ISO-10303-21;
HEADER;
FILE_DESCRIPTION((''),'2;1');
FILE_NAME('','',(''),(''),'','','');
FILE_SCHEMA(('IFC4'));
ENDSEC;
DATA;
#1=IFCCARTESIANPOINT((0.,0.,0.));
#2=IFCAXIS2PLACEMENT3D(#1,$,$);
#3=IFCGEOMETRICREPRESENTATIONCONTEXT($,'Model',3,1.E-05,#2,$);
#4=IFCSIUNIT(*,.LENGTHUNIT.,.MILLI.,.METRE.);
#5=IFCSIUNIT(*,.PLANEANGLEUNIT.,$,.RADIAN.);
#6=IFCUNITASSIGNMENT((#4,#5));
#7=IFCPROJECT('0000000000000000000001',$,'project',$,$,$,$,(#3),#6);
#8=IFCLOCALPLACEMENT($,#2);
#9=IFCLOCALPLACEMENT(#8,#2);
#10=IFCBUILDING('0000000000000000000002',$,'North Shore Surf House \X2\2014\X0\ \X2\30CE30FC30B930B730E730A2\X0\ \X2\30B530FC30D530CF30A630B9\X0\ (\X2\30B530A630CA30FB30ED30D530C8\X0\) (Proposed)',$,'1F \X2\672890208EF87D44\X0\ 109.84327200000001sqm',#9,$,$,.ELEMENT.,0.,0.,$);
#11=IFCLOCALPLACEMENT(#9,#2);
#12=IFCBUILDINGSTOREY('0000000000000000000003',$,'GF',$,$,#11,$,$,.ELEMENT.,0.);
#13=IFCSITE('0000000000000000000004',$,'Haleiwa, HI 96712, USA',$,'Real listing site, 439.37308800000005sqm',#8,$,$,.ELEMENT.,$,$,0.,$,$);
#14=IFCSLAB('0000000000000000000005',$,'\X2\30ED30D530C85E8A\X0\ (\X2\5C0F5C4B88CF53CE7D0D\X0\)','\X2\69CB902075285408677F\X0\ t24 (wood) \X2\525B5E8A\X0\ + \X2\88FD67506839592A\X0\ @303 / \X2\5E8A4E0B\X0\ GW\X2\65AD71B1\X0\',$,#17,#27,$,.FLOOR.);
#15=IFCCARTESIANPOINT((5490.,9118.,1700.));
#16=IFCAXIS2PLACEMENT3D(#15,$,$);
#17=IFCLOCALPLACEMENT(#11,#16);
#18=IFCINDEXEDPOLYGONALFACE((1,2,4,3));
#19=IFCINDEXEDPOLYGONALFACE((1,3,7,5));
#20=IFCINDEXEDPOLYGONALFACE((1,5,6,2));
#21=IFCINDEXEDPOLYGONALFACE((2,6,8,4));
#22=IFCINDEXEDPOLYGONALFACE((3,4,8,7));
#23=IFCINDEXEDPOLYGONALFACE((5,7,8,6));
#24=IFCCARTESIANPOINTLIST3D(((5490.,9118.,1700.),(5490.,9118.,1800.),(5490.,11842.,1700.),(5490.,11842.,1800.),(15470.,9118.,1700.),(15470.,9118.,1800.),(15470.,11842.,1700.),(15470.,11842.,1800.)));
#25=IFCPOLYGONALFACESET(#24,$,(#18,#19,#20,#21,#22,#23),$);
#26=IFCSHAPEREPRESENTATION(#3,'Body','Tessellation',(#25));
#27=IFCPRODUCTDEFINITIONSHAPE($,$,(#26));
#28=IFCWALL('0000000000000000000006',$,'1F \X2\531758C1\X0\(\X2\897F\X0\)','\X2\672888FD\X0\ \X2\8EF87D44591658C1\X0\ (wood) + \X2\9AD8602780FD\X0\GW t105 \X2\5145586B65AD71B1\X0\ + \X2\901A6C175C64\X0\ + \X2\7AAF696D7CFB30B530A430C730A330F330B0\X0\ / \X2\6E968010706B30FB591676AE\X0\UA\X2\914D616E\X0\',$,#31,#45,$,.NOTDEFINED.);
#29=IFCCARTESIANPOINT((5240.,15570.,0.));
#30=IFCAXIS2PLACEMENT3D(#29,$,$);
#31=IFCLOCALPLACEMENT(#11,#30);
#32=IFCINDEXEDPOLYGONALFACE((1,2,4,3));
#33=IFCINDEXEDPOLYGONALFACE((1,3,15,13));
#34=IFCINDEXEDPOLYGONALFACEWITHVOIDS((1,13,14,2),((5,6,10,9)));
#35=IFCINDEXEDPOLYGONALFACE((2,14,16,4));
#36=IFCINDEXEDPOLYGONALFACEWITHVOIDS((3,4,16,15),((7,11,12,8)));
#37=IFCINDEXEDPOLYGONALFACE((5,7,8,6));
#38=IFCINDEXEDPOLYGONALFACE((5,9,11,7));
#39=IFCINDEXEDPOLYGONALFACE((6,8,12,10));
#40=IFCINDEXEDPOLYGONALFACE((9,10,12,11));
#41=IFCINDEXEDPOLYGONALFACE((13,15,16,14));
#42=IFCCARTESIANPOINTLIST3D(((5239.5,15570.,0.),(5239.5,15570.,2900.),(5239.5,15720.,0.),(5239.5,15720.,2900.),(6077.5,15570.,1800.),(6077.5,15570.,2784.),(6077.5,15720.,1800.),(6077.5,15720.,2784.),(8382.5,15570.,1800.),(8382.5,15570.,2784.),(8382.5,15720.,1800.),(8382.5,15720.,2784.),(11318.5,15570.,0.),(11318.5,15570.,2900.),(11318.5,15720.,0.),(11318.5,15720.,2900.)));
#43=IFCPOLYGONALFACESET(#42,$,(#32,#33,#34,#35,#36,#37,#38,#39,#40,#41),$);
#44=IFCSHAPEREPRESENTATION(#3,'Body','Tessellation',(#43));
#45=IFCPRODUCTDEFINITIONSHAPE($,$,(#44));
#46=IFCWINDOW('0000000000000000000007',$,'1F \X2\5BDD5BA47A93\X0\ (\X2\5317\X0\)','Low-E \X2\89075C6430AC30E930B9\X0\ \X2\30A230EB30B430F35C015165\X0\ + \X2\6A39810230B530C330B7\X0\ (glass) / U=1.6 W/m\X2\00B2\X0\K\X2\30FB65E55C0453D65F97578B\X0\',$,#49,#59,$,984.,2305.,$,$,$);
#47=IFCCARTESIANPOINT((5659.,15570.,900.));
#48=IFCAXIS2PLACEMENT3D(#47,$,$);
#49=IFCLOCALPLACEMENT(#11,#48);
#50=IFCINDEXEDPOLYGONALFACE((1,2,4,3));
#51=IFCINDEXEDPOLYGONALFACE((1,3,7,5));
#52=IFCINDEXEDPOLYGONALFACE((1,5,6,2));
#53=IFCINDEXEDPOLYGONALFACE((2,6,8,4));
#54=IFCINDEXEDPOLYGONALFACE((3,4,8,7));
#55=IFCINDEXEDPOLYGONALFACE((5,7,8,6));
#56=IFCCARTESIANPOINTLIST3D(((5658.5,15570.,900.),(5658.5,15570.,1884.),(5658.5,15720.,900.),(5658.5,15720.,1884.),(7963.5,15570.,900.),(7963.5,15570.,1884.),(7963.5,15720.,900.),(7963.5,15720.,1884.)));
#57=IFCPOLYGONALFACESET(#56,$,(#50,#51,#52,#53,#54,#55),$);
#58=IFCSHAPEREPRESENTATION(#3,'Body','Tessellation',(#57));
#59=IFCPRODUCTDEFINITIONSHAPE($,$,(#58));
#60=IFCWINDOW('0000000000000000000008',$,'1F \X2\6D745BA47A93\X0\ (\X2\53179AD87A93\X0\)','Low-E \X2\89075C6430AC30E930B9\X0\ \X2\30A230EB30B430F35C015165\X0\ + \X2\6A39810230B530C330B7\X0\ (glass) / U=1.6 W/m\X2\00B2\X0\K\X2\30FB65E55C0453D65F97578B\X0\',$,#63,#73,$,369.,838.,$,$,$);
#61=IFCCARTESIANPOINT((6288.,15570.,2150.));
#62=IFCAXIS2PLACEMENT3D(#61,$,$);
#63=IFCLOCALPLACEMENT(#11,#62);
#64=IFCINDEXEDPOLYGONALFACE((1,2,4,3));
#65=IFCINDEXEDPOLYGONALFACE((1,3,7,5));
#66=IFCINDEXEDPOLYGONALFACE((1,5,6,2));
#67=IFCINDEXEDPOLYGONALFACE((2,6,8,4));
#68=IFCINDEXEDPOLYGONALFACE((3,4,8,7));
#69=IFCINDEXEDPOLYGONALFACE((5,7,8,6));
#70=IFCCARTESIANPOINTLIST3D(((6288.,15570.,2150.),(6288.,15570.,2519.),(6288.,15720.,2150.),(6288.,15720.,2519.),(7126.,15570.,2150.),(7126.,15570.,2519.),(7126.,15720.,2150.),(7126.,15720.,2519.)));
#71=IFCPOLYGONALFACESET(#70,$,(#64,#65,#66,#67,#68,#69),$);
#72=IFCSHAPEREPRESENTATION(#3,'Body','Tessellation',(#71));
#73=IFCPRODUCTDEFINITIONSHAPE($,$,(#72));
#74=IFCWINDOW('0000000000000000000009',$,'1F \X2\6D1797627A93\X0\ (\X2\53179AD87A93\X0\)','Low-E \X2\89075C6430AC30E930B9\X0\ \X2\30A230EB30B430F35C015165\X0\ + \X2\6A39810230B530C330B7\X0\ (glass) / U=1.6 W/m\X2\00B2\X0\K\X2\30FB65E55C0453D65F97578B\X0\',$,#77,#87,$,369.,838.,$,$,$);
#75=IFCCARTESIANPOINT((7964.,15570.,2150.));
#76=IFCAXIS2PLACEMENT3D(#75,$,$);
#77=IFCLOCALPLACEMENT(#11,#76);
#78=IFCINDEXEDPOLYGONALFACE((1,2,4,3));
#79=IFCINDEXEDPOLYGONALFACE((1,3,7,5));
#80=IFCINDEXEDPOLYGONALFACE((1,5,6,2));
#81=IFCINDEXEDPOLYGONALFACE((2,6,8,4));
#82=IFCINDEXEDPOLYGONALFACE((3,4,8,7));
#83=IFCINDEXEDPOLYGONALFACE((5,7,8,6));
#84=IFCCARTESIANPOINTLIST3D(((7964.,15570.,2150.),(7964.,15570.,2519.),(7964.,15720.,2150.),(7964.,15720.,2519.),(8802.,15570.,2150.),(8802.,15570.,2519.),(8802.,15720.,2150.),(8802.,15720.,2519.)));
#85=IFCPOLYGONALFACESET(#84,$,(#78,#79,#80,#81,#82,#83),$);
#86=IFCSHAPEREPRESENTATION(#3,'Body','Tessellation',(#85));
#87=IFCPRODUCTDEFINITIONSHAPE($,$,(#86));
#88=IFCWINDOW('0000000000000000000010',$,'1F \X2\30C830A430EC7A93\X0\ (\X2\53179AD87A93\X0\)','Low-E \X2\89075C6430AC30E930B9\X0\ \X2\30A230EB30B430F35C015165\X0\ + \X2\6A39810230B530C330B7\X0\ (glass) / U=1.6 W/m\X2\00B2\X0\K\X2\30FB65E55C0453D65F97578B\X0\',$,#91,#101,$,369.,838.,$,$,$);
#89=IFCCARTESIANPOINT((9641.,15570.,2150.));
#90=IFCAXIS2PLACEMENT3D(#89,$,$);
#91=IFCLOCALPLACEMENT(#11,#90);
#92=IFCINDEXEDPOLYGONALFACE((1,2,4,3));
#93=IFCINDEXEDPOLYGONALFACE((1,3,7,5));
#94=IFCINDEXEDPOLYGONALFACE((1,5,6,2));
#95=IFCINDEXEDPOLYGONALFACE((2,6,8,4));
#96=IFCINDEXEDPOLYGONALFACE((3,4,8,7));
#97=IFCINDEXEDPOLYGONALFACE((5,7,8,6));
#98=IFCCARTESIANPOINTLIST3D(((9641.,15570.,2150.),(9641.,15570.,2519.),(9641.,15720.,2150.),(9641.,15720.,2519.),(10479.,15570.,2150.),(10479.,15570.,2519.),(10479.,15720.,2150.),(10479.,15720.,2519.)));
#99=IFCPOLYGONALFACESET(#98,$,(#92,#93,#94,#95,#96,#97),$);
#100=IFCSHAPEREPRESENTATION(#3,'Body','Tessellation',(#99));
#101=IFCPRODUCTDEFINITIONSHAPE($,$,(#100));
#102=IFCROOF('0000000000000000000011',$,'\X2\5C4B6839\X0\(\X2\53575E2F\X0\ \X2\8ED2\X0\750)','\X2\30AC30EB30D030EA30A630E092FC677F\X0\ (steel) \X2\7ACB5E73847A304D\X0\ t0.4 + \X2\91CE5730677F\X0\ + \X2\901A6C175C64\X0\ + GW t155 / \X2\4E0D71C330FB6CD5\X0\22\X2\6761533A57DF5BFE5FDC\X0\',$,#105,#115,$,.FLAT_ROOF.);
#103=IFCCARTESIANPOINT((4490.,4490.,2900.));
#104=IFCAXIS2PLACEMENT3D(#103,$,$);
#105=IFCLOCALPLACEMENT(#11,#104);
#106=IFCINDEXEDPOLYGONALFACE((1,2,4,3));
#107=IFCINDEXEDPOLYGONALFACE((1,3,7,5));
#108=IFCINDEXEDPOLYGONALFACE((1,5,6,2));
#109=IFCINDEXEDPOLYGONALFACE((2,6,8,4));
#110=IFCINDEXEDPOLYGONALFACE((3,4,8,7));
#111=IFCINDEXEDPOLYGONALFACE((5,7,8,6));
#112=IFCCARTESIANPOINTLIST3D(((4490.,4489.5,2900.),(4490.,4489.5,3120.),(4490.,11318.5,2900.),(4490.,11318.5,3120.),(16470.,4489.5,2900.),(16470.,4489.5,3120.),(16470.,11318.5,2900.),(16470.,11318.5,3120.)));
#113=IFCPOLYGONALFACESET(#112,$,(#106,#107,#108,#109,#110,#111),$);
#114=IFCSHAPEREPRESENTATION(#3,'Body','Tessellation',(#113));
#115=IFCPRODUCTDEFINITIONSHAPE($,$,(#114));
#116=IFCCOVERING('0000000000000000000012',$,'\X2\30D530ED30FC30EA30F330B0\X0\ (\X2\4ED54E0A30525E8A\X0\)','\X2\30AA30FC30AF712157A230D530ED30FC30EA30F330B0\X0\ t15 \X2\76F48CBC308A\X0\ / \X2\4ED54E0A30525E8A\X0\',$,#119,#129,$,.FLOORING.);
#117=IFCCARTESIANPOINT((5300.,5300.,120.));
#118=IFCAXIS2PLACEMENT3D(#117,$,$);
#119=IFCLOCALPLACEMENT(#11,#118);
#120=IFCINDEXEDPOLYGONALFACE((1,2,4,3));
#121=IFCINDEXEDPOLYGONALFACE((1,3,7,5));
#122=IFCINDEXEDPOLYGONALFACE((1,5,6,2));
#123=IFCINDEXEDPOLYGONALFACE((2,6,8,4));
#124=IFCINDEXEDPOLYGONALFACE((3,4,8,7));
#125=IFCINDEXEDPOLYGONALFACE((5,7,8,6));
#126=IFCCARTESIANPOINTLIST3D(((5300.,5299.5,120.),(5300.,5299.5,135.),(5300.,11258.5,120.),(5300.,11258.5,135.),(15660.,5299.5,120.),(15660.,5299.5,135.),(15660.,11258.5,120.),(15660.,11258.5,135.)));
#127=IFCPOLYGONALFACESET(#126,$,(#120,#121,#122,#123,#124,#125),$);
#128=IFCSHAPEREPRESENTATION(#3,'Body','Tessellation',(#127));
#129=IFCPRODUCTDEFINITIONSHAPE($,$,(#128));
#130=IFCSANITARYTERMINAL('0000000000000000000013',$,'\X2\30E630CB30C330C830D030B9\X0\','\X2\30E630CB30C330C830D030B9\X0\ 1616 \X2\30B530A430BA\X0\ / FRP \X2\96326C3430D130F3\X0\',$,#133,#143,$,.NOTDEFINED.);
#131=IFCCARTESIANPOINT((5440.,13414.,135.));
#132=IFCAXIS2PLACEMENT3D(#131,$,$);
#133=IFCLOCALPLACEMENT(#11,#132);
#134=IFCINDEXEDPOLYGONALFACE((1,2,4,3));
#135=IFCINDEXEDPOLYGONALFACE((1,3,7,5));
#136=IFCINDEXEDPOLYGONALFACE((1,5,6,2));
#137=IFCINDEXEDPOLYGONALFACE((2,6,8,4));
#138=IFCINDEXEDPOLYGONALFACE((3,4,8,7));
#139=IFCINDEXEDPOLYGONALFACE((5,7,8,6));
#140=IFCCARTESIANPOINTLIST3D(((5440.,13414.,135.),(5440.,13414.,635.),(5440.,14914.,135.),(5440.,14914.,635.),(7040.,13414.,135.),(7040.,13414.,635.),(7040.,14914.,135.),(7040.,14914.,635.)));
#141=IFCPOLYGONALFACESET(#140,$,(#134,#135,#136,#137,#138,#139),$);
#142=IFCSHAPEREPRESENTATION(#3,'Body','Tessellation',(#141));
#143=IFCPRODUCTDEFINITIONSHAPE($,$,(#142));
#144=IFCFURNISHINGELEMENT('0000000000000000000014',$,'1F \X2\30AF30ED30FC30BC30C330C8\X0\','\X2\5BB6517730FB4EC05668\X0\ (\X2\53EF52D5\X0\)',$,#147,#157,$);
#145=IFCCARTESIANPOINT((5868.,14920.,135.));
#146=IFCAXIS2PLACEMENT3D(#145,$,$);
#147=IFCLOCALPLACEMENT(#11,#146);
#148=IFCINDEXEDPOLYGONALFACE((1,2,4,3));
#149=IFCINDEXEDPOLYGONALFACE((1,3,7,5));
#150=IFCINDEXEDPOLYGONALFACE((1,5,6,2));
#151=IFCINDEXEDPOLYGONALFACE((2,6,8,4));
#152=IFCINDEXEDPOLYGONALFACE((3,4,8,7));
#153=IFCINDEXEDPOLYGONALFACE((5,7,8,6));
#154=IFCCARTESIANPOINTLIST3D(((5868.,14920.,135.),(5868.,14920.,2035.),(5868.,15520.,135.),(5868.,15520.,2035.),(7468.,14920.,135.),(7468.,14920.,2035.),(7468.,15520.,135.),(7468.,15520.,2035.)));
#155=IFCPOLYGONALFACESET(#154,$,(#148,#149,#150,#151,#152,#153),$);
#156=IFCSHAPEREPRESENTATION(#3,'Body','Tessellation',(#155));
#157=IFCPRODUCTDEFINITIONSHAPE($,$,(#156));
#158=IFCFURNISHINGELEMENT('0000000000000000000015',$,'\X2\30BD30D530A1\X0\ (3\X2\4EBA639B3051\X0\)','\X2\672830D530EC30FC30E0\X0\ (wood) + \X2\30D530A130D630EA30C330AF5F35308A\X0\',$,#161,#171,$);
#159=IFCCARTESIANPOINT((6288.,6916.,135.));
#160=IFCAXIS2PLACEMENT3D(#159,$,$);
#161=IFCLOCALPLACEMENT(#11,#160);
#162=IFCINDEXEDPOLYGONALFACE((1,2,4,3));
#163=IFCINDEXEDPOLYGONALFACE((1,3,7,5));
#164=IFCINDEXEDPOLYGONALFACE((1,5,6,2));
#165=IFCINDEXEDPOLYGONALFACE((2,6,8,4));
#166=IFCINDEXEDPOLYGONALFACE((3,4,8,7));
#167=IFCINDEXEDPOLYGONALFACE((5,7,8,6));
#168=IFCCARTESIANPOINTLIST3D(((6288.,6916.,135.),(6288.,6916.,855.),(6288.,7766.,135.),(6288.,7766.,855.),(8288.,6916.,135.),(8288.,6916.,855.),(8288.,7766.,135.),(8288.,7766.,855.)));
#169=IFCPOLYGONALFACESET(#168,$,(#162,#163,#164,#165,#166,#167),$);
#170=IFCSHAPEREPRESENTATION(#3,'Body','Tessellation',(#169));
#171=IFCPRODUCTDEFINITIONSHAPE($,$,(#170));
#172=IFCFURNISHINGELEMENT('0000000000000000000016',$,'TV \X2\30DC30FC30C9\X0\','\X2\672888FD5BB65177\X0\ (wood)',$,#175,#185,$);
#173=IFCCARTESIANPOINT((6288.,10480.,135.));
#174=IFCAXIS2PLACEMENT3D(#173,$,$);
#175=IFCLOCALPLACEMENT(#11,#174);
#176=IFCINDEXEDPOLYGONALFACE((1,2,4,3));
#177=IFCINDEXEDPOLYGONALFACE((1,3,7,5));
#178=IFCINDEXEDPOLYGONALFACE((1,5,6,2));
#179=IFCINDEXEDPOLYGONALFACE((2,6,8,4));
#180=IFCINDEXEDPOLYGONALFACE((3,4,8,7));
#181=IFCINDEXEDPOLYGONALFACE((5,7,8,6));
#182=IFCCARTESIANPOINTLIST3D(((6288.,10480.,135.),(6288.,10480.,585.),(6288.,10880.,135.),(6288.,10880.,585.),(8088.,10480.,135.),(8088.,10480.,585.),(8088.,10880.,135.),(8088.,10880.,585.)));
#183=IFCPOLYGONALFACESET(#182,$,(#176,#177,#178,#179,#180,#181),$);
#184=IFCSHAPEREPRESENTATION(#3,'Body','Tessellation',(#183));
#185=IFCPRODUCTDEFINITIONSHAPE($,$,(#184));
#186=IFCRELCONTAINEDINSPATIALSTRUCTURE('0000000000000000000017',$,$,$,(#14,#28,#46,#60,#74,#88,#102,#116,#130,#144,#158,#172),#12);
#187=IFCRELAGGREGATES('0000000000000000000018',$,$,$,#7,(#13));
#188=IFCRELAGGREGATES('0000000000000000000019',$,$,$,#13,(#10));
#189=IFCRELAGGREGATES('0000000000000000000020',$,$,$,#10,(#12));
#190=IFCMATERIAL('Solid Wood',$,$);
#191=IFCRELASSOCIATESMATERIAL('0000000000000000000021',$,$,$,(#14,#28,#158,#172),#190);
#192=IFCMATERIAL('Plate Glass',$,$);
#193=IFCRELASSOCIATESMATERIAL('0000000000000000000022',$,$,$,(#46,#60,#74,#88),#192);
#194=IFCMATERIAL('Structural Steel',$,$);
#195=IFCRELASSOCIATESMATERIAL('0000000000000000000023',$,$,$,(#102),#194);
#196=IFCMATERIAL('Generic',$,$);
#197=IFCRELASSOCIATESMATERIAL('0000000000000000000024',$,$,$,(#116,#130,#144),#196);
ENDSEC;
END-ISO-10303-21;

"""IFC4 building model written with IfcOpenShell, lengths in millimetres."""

from ifc_helpers import new_model, si_unit, frame, frame_2d, origin, place, context, project, spatial, rectangle, extrude, material, element, fill, save


model = new_model("IFC4")

# Units and contexts
model_context = context("Model", 3, precision=1e-05, world=origin())
ifc_project = project(units=[si_unit("LENGTHUNIT", "METRE", prefix="MILLI"), si_unit("PLANEANGLEUNIT", "RADIAN")], contexts=[model_context])

# Site, building, storey
site_placement = place(None, origin())
site = spatial("IfcSite", under=ifc_project, at=site_placement, Name="Haleiwa, HI 96712, USA", ObjectType="Real listing site, 439.37308800000005sqm", CompositionType="ELEMENT", RefElevation=0.0)
building_placement = place(site_placement, origin())
building = spatial("IfcBuilding", under=site, at=building_placement, Name="North Shore Surf House — ノースショア サーフハウス (サウナ・ロフト) (Proposed)", ObjectType="1F 木造軸組 109.84327200000001sqm", CompositionType="ELEMENT", ElevationOfRefHeight=0.0, ElevationOfTerrain=0.0)
storey_placement = place(building_placement, origin())
storey = spatial("IfcBuildingStorey", under=building, at=storey_placement, Name="GF", CompositionType="ELEMENT", Elevation=0.0)

# Slab
ifc_material_1 = material(Name="Solid Wood")
slab_1_placement = place(storey_placement, frame((5490.0, 9118.0, 1700.0)))
element("IfcSlab", 1, at=slab_1_placement, inside=storey, material=ifc_material_1, Name="ロフト床 (小屋裏収納)", Description="構造用合板 t24 (wood) 剛床 + 製材根太 @303 / 床下 GW断熱", PredefinedType="FLOOR", context=model_context, shape_type="SweptSolid", body=[
    extrude(rectangle(XDim=9980.0, YDim=2724.0, at=frame_2d((4990.0, 1362.0))), frame((5490.0, 9118.0, 1700.0)), (0.0, 0.0, 1.0), 100.0),
])

# Shared definitions
ifc_material_2 = material(Name="Plate Glass")

# Wall, openings, windows
wall_1_placement = place(storey_placement, frame((5240.0, 15570.0, 0.0)))
wall_1 = element("IfcWall", 2, at=wall_1_placement, inside=storey, material=ifc_material_1, Name="1F 北壁(西)", Description="木製 軸組外壁 (wood) + 高性能GW t105 充填断熱 + 通気層 + 窯業系サイディング / 準耐火・外皮UA配慮", PredefinedType="NOTDEFINED", context=model_context, shape_type="SweptSolid", body=[
    extrude(rectangle(XDim=6079.0, YDim=150.0, at=frame_2d((3039.0, 75.0))), frame((5240.0, 15570.0, 0.0)), (0.0, 0.0, 1.0), 2900.0),
])
opening_1_placement = place(storey_placement, frame((5659.0, 15570.0, 900.0)))
opening_1 = element("IfcOpeningElement", 3, at=opening_1_placement, cuts=wall_1, PredefinedType="NOTDEFINED", context=model_context, shape_type="SweptSolid", body=[
    extrude(rectangle(XDim=2305.0, YDim=150.0, at=frame_2d((1152.0, 75.0))), frame((5659.0, 15570.0, 900.0)), (0.0, 0.0, 1.0), 984.0),
])
opening_2_placement = place(storey_placement, frame((6288.0, 15570.0, 2150.0)))
opening_2 = element("IfcOpeningElement", 4, at=opening_2_placement, cuts=wall_1, PredefinedType="NOTDEFINED", context=model_context, shape_type="SweptSolid", body=[
    extrude(rectangle(XDim=838.0, YDim=150.0, at=frame_2d((419.0, 75.0))), frame((6288.0, 15570.0, 2150.0)), (0.0, 0.0, 1.0), 369.0),
])
opening_3_placement = place(storey_placement, frame((7964.0, 15570.0, 2150.0)))
opening_3 = element("IfcOpeningElement", 5, at=opening_3_placement, cuts=wall_1, PredefinedType="NOTDEFINED", context=model_context, shape_type="SweptSolid", body=[
    extrude(rectangle(XDim=838.0, YDim=150.0, at=frame_2d((419.0, 75.0))), frame((7964.0, 15570.0, 2150.0)), (0.0, 0.0, 1.0), 369.0),
])
opening_4_placement = place(storey_placement, frame((9641.0, 15570.0, 2150.0)))
opening_4 = element("IfcOpeningElement", 6, at=opening_4_placement, cuts=wall_1, PredefinedType="NOTDEFINED", context=model_context, shape_type="SweptSolid", body=[
    extrude(rectangle(XDim=838.0, YDim=150.0, at=frame_2d((419.0, 75.0))), frame((9641.0, 15570.0, 2150.0)), (0.0, 0.0, 1.0), 369.0),
])
window_1_placement = place(storey_placement, frame((5659.0, 15570.0, 900.0)))
window_1 = element("IfcWindow", 7, at=window_1_placement, inside=storey, material=ifc_material_2, Name="1F 寝室窓 (北)", Description="Low-E 複層ガラス アルゴン封入 + 樹脂サッシ (glass) / U=1.6 W/m²K・日射取得型", OverallHeight=984.0, OverallWidth=2305.0, context=model_context, shape_type="SweptSolid", body=[
    extrude(rectangle(XDim=2305.0, YDim=150.0, at=frame_2d((1152.0, 75.0))), frame((5659.0, 15570.0, 900.0)), (0.0, 0.0, 1.0), 984.0),
])
fill(opening_1, window_1)
window_2_placement = place(storey_placement, frame((6288.0, 15570.0, 2150.0)))
window_2 = element("IfcWindow", 8, at=window_2_placement, inside=storey, material=ifc_material_2, Name="1F 浴室窓 (北高窓)", Description="Low-E 複層ガラス アルゴン封入 + 樹脂サッシ (glass) / U=1.6 W/m²K・日射取得型", OverallHeight=369.0, OverallWidth=838.0, context=model_context, shape_type="SweptSolid", body=[
    extrude(rectangle(XDim=838.0, YDim=150.0, at=frame_2d((419.0, 75.0))), frame((6288.0, 15570.0, 2150.0)), (0.0, 0.0, 1.0), 369.0),
])
fill(opening_2, window_2)
window_3_placement = place(storey_placement, frame((7964.0, 15570.0, 2150.0)))
window_3 = element("IfcWindow", 9, at=window_3_placement, inside=storey, material=ifc_material_2, Name="1F 洗面窓 (北高窓)", Description="Low-E 複層ガラス アルゴン封入 + 樹脂サッシ (glass) / U=1.6 W/m²K・日射取得型", OverallHeight=369.0, OverallWidth=838.0, context=model_context, shape_type="SweptSolid", body=[
    extrude(rectangle(XDim=838.0, YDim=150.0, at=frame_2d((419.0, 75.0))), frame((7964.0, 15570.0, 2150.0)), (0.0, 0.0, 1.0), 369.0),
])
fill(opening_3, window_3)
window_4_placement = place(storey_placement, frame((9641.0, 15570.0, 2150.0)))
window_4 = element("IfcWindow", 10, at=window_4_placement, inside=storey, material=ifc_material_2, Name="1F トイレ窓 (北高窓)", Description="Low-E 複層ガラス アルゴン封入 + 樹脂サッシ (glass) / U=1.6 W/m²K・日射取得型", OverallHeight=369.0, OverallWidth=838.0, context=model_context, shape_type="SweptSolid", body=[
    extrude(rectangle(XDim=838.0, YDim=150.0, at=frame_2d((419.0, 75.0))), frame((9641.0, 15570.0, 2150.0)), (0.0, 0.0, 1.0), 369.0),
])
fill(opening_4, window_4)

# Roof
ifc_material_3 = material(Name="Structural Steel")
roof_1_placement = place(storey_placement, frame((4490.0, 4490.0, 2900.0)))
element("IfcRoof", 11, at=roof_1_placement, inside=storey, material=ifc_material_3, Name="屋根(南帯 軒750)", Description="ガルバリウム鋼板 (steel) 立平葺き t0.4 + 野地板 + 通気層 + GW t155 / 不燃・法22条区域対応", PredefinedType="FLAT_ROOF", context=model_context, shape_type="SweptSolid", body=[
    extrude(rectangle(XDim=11980.0, YDim=6829.0, at=frame_2d((5990.0, 3414.0))), frame((4490.0, 4490.0, 2900.0)), (0.0, 0.0, 1.0), 220.0),
])

# Covering
ifc_material_4 = material(Name="Generic")
covering_1_placement = place(storey_placement, frame((5300.0, 5300.0, 120.0)))
element("IfcCovering", 12, at=covering_1_placement, inside=storey, material=ifc_material_4, Name="フローリング (仕上げ床)", Description="オーク無垢フローリング t15 直貼り / 仕上げ床", PredefinedType="FLOORING", context=model_context, shape_type="SweptSolid", body=[
    extrude(rectangle(XDim=10360.0, YDim=5959.0, at=frame_2d((5180.0, 2979.0))), frame((5300.0, 5300.0, 120.0)), (0.0, 0.0, 1.0), 15.0),
])

# Sanitary terminal
sanitary_terminal_placement = place(storey_placement, frame((5440.0, 13414.0, 135.0)))
element("IfcSanitaryTerminal", 13, at=sanitary_terminal_placement, inside=storey, material=ifc_material_4, Name="ユニットバス", Description="ユニットバス 1616 サイズ / FRP 防水パン", PredefinedType="NOTDEFINED", context=model_context, shape_type="SweptSolid", body=[
    extrude(rectangle(XDim=1600.0, YDim=1500.0, at=frame_2d((800.0, 750.0))), frame((5440.0, 13414.0, 135.0)), (0.0, 0.0, 1.0), 500.0),
])

# Furnishing elements
furnishing_1_placement = place(storey_placement, frame((5868.0, 14920.0, 135.0)))
element("IfcFurnishingElement", 14, at=furnishing_1_placement, inside=storey, material=ifc_material_4, Name="1F クローゼット", Description="家具・什器 (可動)", context=model_context, shape_type="SweptSolid", body=[
    extrude(rectangle(XDim=1600.0, YDim=600.0, at=frame_2d((800.0, 300.0))), frame((5868.0, 14920.0, 135.0)), (0.0, 0.0, 1.0), 1900.0),
])
furnishing_2_placement = place(storey_placement, frame((6288.0, 6916.0, 135.0)))
element("IfcFurnishingElement", 15, at=furnishing_2_placement, inside=storey, material=ifc_material_1, Name="ソファ (3人掛け)", Description="木フレーム (wood) + ファブリック張り", context=model_context, shape_type="SweptSolid", body=[
    extrude(rectangle(XDim=2000.0, YDim=850.0, at=frame_2d((1000.0, 425.0))), frame((6288.0, 6916.0, 135.0)), (0.0, 0.0, 1.0), 720.0),
])
furnishing_3_placement = place(storey_placement, frame((6288.0, 10480.0, 135.0)))
element("IfcFurnishingElement", 16, at=furnishing_3_placement, inside=storey, material=ifc_material_1, Name="TV ボード", Description="木製家具 (wood)", context=model_context, shape_type="SweptSolid", body=[
    extrude(rectangle(XDim=1800.0, YDim=400.0, at=frame_2d((900.0, 200.0))), frame((6288.0, 10480.0, 135.0)), (0.0, 0.0, 1.0), 450.0),
])

save(model, "model.ifc")
